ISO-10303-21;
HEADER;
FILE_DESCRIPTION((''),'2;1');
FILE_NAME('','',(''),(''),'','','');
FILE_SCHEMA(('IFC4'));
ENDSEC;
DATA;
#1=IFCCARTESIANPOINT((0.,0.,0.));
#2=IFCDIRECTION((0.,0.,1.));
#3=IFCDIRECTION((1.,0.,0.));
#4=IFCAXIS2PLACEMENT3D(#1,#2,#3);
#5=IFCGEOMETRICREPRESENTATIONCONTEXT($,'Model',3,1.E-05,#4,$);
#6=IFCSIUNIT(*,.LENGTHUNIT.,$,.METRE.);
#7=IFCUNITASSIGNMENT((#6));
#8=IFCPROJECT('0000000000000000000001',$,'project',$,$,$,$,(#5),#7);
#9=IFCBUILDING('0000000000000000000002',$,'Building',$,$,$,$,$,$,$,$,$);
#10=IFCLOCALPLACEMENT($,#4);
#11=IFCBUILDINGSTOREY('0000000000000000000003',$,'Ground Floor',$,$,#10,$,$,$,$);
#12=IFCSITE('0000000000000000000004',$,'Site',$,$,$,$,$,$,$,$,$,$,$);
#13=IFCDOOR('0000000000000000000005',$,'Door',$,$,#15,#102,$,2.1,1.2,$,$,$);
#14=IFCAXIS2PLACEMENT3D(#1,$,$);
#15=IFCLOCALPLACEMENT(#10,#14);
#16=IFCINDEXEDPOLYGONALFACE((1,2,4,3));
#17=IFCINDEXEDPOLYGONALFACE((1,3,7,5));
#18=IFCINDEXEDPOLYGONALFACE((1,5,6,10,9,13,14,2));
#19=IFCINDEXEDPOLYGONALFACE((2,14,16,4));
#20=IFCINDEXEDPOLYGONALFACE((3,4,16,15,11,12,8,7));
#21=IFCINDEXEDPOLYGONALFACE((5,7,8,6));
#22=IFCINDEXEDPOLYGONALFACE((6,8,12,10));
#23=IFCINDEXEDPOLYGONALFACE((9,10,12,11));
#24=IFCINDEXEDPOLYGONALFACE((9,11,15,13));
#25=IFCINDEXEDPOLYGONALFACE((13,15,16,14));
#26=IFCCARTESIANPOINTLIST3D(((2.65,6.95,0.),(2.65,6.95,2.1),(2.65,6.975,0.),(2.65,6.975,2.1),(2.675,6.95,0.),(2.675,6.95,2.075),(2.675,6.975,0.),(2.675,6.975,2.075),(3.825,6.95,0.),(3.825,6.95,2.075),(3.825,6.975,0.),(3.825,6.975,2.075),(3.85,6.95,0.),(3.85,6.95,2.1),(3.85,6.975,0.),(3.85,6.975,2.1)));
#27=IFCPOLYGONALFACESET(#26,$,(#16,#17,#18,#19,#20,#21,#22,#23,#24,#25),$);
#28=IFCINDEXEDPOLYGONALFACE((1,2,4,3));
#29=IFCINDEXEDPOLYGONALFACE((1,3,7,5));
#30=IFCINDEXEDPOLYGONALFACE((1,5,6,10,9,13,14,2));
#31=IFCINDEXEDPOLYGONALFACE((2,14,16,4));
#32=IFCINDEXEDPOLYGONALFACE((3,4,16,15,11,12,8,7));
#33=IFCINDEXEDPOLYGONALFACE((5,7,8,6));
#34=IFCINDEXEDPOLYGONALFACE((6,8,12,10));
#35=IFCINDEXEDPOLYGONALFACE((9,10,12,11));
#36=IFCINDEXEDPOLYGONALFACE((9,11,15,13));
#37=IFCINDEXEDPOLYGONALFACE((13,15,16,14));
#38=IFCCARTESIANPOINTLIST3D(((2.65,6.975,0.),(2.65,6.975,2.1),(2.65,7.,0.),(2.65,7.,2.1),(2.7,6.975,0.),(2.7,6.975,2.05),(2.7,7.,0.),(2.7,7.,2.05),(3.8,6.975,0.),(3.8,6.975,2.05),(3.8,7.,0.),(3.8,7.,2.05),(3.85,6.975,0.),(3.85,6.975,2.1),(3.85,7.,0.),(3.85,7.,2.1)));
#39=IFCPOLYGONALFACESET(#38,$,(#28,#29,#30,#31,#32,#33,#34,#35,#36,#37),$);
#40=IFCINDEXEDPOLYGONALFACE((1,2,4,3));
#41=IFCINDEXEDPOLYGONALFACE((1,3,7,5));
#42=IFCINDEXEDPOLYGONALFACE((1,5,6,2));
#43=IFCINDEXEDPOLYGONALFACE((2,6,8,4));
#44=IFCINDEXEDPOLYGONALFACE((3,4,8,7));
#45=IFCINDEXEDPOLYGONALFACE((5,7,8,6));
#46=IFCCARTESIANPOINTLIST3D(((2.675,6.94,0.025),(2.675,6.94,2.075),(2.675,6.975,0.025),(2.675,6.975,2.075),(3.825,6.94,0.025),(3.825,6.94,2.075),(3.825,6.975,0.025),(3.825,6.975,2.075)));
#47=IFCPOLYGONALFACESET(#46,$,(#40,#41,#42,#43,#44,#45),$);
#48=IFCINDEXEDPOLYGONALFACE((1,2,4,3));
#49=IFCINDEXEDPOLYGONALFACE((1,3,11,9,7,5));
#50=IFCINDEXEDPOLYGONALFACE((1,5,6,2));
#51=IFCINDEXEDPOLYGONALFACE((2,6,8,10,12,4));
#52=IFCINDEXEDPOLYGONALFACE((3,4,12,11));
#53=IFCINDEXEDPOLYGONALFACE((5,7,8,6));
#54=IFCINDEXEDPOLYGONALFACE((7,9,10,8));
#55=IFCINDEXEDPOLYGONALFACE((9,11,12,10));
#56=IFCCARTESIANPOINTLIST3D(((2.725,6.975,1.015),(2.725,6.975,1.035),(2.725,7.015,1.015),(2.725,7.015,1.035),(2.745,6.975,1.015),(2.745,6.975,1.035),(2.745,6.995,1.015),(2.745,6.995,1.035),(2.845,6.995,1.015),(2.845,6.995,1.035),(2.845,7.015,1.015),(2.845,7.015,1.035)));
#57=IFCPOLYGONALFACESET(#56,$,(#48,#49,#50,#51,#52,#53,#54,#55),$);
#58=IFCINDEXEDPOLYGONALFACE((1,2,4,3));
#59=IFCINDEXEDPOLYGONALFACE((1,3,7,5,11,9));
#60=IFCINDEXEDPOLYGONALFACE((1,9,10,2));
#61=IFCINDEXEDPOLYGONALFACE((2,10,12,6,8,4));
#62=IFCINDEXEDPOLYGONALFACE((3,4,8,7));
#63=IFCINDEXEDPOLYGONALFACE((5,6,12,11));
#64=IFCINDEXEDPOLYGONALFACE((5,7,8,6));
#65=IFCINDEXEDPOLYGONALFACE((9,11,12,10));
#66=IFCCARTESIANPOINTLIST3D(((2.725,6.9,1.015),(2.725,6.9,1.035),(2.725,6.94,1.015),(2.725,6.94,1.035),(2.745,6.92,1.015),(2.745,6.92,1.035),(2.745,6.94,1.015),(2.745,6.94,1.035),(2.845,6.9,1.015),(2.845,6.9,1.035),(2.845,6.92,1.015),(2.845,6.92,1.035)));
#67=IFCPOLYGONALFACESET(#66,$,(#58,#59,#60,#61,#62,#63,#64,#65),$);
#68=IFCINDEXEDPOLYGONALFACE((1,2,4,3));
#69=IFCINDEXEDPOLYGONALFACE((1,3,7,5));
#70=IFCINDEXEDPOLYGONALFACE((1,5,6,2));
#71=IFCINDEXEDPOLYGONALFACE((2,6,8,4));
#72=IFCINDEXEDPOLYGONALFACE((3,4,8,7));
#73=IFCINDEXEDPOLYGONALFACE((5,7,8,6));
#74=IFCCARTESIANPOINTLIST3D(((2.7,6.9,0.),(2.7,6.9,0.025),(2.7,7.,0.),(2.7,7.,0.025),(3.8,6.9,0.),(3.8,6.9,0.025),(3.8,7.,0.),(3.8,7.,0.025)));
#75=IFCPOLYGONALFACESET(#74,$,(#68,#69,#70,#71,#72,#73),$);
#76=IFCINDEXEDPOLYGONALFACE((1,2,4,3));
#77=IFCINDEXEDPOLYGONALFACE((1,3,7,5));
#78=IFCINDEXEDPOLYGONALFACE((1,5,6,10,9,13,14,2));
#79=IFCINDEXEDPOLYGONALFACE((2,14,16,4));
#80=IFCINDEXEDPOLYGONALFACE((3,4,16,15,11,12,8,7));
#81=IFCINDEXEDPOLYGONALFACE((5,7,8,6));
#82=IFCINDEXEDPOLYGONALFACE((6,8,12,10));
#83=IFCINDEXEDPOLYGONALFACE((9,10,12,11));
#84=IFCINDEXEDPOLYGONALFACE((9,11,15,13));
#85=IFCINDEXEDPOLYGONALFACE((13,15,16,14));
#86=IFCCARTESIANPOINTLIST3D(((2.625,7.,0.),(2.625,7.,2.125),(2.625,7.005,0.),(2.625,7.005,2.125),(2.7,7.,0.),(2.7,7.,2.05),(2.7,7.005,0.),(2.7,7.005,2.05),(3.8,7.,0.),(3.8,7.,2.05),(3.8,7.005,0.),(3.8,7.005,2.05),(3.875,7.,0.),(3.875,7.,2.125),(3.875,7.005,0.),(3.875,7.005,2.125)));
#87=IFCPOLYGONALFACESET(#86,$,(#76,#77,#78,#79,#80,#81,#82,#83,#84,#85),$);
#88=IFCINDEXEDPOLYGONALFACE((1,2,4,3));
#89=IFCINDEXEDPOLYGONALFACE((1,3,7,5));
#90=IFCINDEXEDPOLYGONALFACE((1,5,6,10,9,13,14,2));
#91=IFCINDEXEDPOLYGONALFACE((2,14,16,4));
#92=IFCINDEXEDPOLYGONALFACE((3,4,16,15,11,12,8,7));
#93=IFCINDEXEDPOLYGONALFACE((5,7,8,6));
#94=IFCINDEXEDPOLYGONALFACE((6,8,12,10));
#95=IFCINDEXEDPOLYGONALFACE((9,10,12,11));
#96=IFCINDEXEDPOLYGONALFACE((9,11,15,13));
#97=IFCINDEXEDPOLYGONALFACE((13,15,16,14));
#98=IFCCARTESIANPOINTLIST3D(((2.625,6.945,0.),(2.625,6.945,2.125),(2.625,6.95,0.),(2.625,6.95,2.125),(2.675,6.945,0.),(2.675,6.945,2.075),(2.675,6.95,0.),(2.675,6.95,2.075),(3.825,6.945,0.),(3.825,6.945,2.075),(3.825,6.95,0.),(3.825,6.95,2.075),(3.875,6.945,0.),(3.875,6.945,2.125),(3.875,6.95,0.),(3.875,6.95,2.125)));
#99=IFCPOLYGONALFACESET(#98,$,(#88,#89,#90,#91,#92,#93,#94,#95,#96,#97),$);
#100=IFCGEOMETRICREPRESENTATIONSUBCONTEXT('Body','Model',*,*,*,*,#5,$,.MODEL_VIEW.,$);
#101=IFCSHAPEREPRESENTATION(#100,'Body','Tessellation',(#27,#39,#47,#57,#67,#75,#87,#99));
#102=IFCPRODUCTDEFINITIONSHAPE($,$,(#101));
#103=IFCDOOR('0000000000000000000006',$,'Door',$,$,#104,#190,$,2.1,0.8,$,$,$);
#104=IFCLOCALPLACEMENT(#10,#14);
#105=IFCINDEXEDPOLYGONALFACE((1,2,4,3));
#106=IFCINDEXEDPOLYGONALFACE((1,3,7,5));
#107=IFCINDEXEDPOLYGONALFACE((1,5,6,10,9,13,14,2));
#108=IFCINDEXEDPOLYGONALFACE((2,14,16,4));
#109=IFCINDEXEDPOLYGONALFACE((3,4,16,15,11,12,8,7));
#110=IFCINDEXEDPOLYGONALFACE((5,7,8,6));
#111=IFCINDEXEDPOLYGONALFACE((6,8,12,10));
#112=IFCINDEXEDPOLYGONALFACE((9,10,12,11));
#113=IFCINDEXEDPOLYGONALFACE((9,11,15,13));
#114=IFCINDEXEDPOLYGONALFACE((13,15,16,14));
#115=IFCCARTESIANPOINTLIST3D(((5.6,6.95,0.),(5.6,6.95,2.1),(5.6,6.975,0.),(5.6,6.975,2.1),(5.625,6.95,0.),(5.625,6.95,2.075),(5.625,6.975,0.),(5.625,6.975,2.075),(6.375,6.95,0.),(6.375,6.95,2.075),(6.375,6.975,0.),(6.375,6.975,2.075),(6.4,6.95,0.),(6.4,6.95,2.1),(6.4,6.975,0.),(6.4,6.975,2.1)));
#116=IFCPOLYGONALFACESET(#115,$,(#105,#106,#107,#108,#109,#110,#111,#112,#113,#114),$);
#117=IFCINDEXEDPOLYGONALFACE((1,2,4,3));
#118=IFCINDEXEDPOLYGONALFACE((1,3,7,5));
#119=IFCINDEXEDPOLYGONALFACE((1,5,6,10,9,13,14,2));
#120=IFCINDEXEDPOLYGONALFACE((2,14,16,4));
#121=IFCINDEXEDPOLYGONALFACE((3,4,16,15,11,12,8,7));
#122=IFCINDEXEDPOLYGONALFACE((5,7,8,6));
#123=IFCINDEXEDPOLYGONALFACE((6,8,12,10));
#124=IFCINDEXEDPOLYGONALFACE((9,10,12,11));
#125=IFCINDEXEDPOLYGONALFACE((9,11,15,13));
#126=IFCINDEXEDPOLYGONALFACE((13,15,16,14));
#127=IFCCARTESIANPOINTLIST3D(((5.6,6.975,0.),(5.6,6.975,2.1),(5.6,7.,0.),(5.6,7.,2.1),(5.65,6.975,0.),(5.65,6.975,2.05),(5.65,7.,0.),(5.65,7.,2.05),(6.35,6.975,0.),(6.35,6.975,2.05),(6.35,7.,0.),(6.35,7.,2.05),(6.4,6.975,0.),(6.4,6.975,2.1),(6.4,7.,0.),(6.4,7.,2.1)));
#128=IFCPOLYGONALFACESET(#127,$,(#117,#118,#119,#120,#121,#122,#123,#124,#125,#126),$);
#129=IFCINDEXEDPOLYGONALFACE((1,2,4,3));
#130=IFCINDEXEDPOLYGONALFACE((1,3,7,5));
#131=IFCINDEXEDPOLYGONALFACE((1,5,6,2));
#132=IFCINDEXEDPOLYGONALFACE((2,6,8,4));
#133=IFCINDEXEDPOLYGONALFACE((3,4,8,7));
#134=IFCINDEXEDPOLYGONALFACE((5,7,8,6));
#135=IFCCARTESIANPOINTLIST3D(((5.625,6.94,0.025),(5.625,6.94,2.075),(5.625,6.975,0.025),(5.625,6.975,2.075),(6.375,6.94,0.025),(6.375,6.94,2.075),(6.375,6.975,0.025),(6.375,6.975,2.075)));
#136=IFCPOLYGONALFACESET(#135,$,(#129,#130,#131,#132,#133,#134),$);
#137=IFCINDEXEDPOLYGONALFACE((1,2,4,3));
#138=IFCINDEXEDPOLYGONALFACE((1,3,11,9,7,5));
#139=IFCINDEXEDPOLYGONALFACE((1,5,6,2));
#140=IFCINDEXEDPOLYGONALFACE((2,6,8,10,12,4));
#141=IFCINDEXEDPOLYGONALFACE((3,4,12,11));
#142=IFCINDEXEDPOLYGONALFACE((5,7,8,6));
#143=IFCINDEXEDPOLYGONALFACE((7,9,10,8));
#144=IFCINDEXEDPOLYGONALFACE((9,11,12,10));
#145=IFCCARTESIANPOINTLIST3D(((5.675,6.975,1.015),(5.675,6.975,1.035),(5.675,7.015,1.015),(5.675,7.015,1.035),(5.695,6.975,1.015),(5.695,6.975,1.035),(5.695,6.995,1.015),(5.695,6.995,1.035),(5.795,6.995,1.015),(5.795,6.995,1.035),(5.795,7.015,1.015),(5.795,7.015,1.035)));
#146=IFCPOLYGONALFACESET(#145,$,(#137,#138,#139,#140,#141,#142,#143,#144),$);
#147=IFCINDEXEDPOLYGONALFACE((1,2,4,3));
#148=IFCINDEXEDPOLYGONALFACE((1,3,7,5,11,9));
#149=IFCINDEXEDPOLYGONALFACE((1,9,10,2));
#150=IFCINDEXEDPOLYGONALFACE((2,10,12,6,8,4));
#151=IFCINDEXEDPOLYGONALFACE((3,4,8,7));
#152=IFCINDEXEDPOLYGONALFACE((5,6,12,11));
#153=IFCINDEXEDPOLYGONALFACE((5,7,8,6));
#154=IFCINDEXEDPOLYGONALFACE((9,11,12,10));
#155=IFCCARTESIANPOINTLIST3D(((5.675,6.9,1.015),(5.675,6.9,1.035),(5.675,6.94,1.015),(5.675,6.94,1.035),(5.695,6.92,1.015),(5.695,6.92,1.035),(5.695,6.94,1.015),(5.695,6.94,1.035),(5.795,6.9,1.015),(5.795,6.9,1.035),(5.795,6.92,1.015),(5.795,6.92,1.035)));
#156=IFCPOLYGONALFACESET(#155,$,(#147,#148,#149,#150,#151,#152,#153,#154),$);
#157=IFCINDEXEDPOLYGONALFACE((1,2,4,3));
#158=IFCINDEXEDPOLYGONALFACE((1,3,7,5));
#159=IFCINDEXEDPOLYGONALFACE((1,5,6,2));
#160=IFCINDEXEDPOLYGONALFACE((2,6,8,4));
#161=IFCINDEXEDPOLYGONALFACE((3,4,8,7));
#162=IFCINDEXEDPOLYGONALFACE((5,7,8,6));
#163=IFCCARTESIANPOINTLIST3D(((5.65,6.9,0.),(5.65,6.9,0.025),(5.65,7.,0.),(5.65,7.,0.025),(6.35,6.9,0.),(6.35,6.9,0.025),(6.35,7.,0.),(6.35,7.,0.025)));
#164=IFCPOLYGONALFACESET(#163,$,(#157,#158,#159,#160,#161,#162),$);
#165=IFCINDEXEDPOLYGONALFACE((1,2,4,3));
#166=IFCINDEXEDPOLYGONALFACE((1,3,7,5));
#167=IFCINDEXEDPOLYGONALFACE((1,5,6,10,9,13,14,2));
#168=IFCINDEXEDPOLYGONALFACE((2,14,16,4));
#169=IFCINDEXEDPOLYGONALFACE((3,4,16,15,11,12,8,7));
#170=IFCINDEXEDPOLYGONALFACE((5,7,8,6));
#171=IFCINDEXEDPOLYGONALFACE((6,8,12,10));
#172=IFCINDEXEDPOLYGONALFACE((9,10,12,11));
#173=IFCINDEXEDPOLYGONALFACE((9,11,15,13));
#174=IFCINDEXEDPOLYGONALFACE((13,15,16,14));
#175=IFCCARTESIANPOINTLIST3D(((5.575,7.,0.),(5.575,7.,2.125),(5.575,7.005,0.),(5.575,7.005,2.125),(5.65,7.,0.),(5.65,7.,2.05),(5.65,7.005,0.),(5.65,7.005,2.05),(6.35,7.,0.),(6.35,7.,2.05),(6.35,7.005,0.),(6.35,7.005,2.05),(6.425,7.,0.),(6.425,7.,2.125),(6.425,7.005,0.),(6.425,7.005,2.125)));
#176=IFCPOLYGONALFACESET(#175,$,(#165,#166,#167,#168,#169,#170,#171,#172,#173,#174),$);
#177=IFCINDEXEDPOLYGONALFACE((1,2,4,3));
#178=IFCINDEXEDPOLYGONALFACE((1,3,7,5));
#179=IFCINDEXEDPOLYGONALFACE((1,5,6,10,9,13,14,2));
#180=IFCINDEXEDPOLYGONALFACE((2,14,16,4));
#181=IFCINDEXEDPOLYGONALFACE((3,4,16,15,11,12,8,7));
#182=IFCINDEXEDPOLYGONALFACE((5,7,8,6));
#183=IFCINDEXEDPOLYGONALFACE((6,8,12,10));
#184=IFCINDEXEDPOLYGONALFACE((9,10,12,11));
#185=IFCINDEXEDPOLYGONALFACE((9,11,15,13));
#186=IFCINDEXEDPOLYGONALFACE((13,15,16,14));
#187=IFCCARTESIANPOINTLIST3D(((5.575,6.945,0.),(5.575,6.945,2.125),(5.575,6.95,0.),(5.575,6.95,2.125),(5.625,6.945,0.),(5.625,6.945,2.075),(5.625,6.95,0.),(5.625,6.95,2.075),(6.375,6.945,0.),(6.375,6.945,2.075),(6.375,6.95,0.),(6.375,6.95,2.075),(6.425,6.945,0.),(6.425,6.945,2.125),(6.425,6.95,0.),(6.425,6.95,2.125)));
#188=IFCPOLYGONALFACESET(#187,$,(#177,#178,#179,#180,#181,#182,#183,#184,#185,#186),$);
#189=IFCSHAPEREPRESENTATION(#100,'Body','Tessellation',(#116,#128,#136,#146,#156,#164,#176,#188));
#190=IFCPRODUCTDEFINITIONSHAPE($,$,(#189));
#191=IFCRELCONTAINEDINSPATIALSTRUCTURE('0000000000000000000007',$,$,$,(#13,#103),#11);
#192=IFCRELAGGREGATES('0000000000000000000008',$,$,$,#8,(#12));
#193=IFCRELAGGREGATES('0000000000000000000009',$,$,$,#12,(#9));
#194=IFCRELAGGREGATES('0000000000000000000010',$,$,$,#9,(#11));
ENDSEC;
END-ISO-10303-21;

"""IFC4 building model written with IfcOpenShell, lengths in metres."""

from ifc_helpers import new_model, si_unit, frame, origin_with_axes, place, context, subcontext, project, spatial, line, indexed_curve, outline, extrude, element, save


model = new_model("IFC4")

# Units and contexts
model_context = context("Model", 3, precision=1e-05, world=origin_with_axes())
body_context = subcontext(model_context, "Body", "Model", "MODEL_VIEW")
ifc_project = project(units=[si_unit("LENGTHUNIT", "METRE")], contexts=[model_context])

# Site, building, storey
site = spatial("IfcSite", under=ifc_project, Name="Site")
building = spatial("IfcBuilding", under=site, Name="Building")
storey_placement = place(None, origin_with_axes())
storey = spatial("IfcBuildingStorey", under=building, at=storey_placement, Name="Ground Floor")

# Doors
door_1_placement = place(storey_placement, frame((3.85, 7.0, 0.0), z_axis=(0.0, 0.0, 1.0), x_axis=(-1.0, 0.0, 0.0)))
element("IfcDoor", 1, at=door_1_placement, inside=storey, Name="Door", OverallHeight=2.1, OverallWidth=1.2, context=body_context, shape_type="SweptSolid", body=[
    extrude(outline(indexed_curve([(0.0, 0.0), (0.0, 2.1), (1.2, 2.1), (1.2, 0.0), (1.175, 0.0), (1.175, 2.075), (0.025, 2.075), (0.025, 0.0)], segments=[line(1, 2, 3, 4, 5, 6, 7, 8, 1)])), frame((0.0, 0.025, 0.0), z_axis=(0.0, -1.0, 0.0), x_axis=(1.0, 0.0, 0.0)), (0.0, 0.0, -1.0), 0.025),
    extrude(outline(indexed_curve([(0.0, 0.0), (0.0, 2.1), (1.2, 2.1), (1.2, 0.0), (1.15, 0.0), (1.15, 2.05), (0.05, 2.05), (0.05, 0.0)], segments=[line(1, 2, 3, 4, 5, 6, 7, 8, 1)])), frame((0.0, 0.0, 0.0), z_axis=(0.0, -1.0, 0.0), x_axis=(1.0, 0.0, 0.0)), (0.0, 0.0, -1.0), 0.025),
    extrude(outline(indexed_curve([(0.0, 0.0), (1.15, 0.0), (1.15, 0.035), (0.0, 0.035)], segments=[line(1, 2, 3, 4, 1)])), frame((0.025, 0.025, 0.025), z_axis=(0.0, 0.0, 1.0), x_axis=(1.0, 0.0, 0.0)), (0.0, 0.0, 1.0), 2.05),
    extrude(outline(indexed_curve([(0.0, 0.0), (0.0, -0.04), (-0.12, -0.04), (-0.12, -0.02), (-0.02, -0.02), (-0.02, 0.0)], segments=[line(1, 2, 3, 4, 5, 6, 1)])), frame((1.125, 0.025, 1.015), z_axis=(0.0, 0.0, 1.0), x_axis=(1.0, 0.0, 0.0)), (0.0, 0.0, 1.0), 0.02),
    extrude(outline(indexed_curve([(0.0, 0.0), (0.0, 0.04), (-0.12, 0.04), (-0.12, 0.02), (-0.02, 0.02), (-0.02, 0.0)], segments=[line(1, 2, 3, 4, 5, 6, 1)])), frame((1.125, 0.06, 1.015), z_axis=(0.0, 0.0, 1.0), x_axis=(1.0, 0.0, 0.0)), (0.0, 0.0, 1.0), 0.02),
    extrude(outline(indexed_curve([(0.0, 0.0), (1.1, 0.0), (1.1, 0.1), (0.0, 0.1)], segments=[line(1, 2, 3, 4, 1)])), frame((0.05, 0.0, 0.0), z_axis=(0.0, 0.0, 1.0), x_axis=(1.0, 0.0, 0.0)), (0.0, 0.0, 1.0), 0.025),
    extrude(outline(indexed_curve([(0.0, 0.0), (0.0, 2.125), (1.25, 2.125), (1.25, 0.0), (1.175, 0.0), (1.175, 2.05), (0.075, 2.05), (0.075, 0.0)], segments=[line(1, 2, 3, 4, 5, 6, 7, 8, 1)])), frame((-0.025, -0.005, 0.0), z_axis=(0.0, -1.0, 0.0), x_axis=(1.0, 0.0, 0.0)), (0.0, 0.0, -1.0), 0.005),
    extrude(outline(indexed_curve([(0.0, 0.0), (0.0, 2.125), (1.25, 2.125), (1.25, 0.0), (1.2, 0.0), (1.2, 2.075), (0.05, 2.075), (0.05, 0.0)], segments=[line(1, 2, 3, 4, 5, 6, 7, 8, 1)])), frame((-0.025, 0.05, 0.0), z_axis=(0.0, -1.0, 0.0), x_axis=(1.0, 0.0, 0.0)), (0.0, 0.0, -1.0), 0.005),
])
door_2_placement = place(storey_placement, frame((6.4, 7.0, 0.0), z_axis=(0.0, 0.0, 1.0), x_axis=(-1.0, 0.0, 0.0)))
element("IfcDoor", 2, at=door_2_placement, inside=storey, Name="Door", OverallHeight=2.1, OverallWidth=0.8, context=body_context, shape_type="SweptSolid", body=[
    extrude(outline(indexed_curve([(0.0, 0.0), (0.0, 2.1), (0.8, 2.1), (0.8, 0.0), (0.775, 0.0), (0.775, 2.075), (0.025, 2.075), (0.025, 0.0)], segments=[line(1, 2, 3, 4, 5, 6, 7, 8, 1)])), frame((0.0, 0.025, 0.0), z_axis=(0.0, -1.0, 0.0), x_axis=(1.0, 0.0, 0.0)), (0.0, 0.0, -1.0), 0.025),
    extrude(outline(indexed_curve([(0.0, 0.0), (0.0, 2.1), (0.8, 2.1), (0.8, 0.0), (0.75, 0.0), (0.75, 2.05), (0.05, 2.05), (0.05, 0.0)], segments=[line(1, 2, 3, 4, 5, 6, 7, 8, 1)])), frame((0.0, 0.0, 0.0), z_axis=(0.0, -1.0, 0.0), x_axis=(1.0, 0.0, 0.0)), (0.0, 0.0, -1.0), 0.025),
    extrude(outline(indexed_curve([(0.0, 0.0), (0.75, 0.0), (0.75, 0.035), (0.0, 0.035)], segments=[line(1, 2, 3, 4, 1)])), frame((0.025, 0.025, 0.025), z_axis=(0.0, 0.0, 1.0), x_axis=(1.0, 0.0, 0.0)), (0.0, 0.0, 1.0), 2.05),
    extrude(outline(indexed_curve([(0.0, 0.0), (0.0, -0.04), (-0.12, -0.04), (-0.12, -0.02), (-0.02, -0.02), (-0.02, 0.0)], segments=[line(1, 2, 3, 4, 5, 6, 1)])), frame((0.725, 0.025, 1.015), z_axis=(0.0, 0.0, 1.0), x_axis=(1.0, 0.0, 0.0)), (0.0, 0.0, 1.0), 0.02),
    extrude(outline(indexed_curve([(0.0, 0.0), (0.0, 0.04), (-0.12, 0.04), (-0.12, 0.02), (-0.02, 0.02), (-0.02, 0.0)], segments=[line(1, 2, 3, 4, 5, 6, 1)])), frame((0.725, 0.06, 1.015), z_axis=(0.0, 0.0, 1.0), x_axis=(1.0, 0.0, 0.0)), (0.0, 0.0, 1.0), 0.02),
    extrude(outline(indexed_curve([(0.0, 0.0), (0.7, 0.0), (0.7, 0.1), (0.0, 0.1)], segments=[line(1, 2, 3, 4, 1)])), frame((0.05, 0.0, 0.0), z_axis=(0.0, 0.0, 1.0), x_axis=(1.0, 0.0, 0.0)), (0.0, 0.0, 1.0), 0.025),
    extrude(outline(indexed_curve([(0.0, 0.0), (0.0, 2.125), (0.85, 2.125), (0.85, 0.0), (0.775, 0.0), (0.775, 2.05), (0.075, 2.05), (0.075, 0.0)], segments=[line(1, 2, 3, 4, 5, 6, 7, 8, 1)])), frame((-0.025, -0.005, 0.0), z_axis=(0.0, -1.0, 0.0), x_axis=(1.0, 0.0, 0.0)), (0.0, 0.0, -1.0), 0.005),
    extrude(outline(indexed_curve([(0.0, 0.0), (0.0, 2.125), (0.85, 2.125), (0.85, 0.0), (0.8, 0.0), (0.8, 2.075), (0.05, 2.075), (0.05, 0.0)], segments=[line(1, 2, 3, 4, 5, 6, 7, 8, 1)])), frame((-0.025, 0.05, 0.0), z_axis=(0.0, -1.0, 0.0), x_axis=(1.0, 0.0, 0.0)), (0.0, 0.0, -1.0), 0.005),
])

save(model, "model.ifc")
